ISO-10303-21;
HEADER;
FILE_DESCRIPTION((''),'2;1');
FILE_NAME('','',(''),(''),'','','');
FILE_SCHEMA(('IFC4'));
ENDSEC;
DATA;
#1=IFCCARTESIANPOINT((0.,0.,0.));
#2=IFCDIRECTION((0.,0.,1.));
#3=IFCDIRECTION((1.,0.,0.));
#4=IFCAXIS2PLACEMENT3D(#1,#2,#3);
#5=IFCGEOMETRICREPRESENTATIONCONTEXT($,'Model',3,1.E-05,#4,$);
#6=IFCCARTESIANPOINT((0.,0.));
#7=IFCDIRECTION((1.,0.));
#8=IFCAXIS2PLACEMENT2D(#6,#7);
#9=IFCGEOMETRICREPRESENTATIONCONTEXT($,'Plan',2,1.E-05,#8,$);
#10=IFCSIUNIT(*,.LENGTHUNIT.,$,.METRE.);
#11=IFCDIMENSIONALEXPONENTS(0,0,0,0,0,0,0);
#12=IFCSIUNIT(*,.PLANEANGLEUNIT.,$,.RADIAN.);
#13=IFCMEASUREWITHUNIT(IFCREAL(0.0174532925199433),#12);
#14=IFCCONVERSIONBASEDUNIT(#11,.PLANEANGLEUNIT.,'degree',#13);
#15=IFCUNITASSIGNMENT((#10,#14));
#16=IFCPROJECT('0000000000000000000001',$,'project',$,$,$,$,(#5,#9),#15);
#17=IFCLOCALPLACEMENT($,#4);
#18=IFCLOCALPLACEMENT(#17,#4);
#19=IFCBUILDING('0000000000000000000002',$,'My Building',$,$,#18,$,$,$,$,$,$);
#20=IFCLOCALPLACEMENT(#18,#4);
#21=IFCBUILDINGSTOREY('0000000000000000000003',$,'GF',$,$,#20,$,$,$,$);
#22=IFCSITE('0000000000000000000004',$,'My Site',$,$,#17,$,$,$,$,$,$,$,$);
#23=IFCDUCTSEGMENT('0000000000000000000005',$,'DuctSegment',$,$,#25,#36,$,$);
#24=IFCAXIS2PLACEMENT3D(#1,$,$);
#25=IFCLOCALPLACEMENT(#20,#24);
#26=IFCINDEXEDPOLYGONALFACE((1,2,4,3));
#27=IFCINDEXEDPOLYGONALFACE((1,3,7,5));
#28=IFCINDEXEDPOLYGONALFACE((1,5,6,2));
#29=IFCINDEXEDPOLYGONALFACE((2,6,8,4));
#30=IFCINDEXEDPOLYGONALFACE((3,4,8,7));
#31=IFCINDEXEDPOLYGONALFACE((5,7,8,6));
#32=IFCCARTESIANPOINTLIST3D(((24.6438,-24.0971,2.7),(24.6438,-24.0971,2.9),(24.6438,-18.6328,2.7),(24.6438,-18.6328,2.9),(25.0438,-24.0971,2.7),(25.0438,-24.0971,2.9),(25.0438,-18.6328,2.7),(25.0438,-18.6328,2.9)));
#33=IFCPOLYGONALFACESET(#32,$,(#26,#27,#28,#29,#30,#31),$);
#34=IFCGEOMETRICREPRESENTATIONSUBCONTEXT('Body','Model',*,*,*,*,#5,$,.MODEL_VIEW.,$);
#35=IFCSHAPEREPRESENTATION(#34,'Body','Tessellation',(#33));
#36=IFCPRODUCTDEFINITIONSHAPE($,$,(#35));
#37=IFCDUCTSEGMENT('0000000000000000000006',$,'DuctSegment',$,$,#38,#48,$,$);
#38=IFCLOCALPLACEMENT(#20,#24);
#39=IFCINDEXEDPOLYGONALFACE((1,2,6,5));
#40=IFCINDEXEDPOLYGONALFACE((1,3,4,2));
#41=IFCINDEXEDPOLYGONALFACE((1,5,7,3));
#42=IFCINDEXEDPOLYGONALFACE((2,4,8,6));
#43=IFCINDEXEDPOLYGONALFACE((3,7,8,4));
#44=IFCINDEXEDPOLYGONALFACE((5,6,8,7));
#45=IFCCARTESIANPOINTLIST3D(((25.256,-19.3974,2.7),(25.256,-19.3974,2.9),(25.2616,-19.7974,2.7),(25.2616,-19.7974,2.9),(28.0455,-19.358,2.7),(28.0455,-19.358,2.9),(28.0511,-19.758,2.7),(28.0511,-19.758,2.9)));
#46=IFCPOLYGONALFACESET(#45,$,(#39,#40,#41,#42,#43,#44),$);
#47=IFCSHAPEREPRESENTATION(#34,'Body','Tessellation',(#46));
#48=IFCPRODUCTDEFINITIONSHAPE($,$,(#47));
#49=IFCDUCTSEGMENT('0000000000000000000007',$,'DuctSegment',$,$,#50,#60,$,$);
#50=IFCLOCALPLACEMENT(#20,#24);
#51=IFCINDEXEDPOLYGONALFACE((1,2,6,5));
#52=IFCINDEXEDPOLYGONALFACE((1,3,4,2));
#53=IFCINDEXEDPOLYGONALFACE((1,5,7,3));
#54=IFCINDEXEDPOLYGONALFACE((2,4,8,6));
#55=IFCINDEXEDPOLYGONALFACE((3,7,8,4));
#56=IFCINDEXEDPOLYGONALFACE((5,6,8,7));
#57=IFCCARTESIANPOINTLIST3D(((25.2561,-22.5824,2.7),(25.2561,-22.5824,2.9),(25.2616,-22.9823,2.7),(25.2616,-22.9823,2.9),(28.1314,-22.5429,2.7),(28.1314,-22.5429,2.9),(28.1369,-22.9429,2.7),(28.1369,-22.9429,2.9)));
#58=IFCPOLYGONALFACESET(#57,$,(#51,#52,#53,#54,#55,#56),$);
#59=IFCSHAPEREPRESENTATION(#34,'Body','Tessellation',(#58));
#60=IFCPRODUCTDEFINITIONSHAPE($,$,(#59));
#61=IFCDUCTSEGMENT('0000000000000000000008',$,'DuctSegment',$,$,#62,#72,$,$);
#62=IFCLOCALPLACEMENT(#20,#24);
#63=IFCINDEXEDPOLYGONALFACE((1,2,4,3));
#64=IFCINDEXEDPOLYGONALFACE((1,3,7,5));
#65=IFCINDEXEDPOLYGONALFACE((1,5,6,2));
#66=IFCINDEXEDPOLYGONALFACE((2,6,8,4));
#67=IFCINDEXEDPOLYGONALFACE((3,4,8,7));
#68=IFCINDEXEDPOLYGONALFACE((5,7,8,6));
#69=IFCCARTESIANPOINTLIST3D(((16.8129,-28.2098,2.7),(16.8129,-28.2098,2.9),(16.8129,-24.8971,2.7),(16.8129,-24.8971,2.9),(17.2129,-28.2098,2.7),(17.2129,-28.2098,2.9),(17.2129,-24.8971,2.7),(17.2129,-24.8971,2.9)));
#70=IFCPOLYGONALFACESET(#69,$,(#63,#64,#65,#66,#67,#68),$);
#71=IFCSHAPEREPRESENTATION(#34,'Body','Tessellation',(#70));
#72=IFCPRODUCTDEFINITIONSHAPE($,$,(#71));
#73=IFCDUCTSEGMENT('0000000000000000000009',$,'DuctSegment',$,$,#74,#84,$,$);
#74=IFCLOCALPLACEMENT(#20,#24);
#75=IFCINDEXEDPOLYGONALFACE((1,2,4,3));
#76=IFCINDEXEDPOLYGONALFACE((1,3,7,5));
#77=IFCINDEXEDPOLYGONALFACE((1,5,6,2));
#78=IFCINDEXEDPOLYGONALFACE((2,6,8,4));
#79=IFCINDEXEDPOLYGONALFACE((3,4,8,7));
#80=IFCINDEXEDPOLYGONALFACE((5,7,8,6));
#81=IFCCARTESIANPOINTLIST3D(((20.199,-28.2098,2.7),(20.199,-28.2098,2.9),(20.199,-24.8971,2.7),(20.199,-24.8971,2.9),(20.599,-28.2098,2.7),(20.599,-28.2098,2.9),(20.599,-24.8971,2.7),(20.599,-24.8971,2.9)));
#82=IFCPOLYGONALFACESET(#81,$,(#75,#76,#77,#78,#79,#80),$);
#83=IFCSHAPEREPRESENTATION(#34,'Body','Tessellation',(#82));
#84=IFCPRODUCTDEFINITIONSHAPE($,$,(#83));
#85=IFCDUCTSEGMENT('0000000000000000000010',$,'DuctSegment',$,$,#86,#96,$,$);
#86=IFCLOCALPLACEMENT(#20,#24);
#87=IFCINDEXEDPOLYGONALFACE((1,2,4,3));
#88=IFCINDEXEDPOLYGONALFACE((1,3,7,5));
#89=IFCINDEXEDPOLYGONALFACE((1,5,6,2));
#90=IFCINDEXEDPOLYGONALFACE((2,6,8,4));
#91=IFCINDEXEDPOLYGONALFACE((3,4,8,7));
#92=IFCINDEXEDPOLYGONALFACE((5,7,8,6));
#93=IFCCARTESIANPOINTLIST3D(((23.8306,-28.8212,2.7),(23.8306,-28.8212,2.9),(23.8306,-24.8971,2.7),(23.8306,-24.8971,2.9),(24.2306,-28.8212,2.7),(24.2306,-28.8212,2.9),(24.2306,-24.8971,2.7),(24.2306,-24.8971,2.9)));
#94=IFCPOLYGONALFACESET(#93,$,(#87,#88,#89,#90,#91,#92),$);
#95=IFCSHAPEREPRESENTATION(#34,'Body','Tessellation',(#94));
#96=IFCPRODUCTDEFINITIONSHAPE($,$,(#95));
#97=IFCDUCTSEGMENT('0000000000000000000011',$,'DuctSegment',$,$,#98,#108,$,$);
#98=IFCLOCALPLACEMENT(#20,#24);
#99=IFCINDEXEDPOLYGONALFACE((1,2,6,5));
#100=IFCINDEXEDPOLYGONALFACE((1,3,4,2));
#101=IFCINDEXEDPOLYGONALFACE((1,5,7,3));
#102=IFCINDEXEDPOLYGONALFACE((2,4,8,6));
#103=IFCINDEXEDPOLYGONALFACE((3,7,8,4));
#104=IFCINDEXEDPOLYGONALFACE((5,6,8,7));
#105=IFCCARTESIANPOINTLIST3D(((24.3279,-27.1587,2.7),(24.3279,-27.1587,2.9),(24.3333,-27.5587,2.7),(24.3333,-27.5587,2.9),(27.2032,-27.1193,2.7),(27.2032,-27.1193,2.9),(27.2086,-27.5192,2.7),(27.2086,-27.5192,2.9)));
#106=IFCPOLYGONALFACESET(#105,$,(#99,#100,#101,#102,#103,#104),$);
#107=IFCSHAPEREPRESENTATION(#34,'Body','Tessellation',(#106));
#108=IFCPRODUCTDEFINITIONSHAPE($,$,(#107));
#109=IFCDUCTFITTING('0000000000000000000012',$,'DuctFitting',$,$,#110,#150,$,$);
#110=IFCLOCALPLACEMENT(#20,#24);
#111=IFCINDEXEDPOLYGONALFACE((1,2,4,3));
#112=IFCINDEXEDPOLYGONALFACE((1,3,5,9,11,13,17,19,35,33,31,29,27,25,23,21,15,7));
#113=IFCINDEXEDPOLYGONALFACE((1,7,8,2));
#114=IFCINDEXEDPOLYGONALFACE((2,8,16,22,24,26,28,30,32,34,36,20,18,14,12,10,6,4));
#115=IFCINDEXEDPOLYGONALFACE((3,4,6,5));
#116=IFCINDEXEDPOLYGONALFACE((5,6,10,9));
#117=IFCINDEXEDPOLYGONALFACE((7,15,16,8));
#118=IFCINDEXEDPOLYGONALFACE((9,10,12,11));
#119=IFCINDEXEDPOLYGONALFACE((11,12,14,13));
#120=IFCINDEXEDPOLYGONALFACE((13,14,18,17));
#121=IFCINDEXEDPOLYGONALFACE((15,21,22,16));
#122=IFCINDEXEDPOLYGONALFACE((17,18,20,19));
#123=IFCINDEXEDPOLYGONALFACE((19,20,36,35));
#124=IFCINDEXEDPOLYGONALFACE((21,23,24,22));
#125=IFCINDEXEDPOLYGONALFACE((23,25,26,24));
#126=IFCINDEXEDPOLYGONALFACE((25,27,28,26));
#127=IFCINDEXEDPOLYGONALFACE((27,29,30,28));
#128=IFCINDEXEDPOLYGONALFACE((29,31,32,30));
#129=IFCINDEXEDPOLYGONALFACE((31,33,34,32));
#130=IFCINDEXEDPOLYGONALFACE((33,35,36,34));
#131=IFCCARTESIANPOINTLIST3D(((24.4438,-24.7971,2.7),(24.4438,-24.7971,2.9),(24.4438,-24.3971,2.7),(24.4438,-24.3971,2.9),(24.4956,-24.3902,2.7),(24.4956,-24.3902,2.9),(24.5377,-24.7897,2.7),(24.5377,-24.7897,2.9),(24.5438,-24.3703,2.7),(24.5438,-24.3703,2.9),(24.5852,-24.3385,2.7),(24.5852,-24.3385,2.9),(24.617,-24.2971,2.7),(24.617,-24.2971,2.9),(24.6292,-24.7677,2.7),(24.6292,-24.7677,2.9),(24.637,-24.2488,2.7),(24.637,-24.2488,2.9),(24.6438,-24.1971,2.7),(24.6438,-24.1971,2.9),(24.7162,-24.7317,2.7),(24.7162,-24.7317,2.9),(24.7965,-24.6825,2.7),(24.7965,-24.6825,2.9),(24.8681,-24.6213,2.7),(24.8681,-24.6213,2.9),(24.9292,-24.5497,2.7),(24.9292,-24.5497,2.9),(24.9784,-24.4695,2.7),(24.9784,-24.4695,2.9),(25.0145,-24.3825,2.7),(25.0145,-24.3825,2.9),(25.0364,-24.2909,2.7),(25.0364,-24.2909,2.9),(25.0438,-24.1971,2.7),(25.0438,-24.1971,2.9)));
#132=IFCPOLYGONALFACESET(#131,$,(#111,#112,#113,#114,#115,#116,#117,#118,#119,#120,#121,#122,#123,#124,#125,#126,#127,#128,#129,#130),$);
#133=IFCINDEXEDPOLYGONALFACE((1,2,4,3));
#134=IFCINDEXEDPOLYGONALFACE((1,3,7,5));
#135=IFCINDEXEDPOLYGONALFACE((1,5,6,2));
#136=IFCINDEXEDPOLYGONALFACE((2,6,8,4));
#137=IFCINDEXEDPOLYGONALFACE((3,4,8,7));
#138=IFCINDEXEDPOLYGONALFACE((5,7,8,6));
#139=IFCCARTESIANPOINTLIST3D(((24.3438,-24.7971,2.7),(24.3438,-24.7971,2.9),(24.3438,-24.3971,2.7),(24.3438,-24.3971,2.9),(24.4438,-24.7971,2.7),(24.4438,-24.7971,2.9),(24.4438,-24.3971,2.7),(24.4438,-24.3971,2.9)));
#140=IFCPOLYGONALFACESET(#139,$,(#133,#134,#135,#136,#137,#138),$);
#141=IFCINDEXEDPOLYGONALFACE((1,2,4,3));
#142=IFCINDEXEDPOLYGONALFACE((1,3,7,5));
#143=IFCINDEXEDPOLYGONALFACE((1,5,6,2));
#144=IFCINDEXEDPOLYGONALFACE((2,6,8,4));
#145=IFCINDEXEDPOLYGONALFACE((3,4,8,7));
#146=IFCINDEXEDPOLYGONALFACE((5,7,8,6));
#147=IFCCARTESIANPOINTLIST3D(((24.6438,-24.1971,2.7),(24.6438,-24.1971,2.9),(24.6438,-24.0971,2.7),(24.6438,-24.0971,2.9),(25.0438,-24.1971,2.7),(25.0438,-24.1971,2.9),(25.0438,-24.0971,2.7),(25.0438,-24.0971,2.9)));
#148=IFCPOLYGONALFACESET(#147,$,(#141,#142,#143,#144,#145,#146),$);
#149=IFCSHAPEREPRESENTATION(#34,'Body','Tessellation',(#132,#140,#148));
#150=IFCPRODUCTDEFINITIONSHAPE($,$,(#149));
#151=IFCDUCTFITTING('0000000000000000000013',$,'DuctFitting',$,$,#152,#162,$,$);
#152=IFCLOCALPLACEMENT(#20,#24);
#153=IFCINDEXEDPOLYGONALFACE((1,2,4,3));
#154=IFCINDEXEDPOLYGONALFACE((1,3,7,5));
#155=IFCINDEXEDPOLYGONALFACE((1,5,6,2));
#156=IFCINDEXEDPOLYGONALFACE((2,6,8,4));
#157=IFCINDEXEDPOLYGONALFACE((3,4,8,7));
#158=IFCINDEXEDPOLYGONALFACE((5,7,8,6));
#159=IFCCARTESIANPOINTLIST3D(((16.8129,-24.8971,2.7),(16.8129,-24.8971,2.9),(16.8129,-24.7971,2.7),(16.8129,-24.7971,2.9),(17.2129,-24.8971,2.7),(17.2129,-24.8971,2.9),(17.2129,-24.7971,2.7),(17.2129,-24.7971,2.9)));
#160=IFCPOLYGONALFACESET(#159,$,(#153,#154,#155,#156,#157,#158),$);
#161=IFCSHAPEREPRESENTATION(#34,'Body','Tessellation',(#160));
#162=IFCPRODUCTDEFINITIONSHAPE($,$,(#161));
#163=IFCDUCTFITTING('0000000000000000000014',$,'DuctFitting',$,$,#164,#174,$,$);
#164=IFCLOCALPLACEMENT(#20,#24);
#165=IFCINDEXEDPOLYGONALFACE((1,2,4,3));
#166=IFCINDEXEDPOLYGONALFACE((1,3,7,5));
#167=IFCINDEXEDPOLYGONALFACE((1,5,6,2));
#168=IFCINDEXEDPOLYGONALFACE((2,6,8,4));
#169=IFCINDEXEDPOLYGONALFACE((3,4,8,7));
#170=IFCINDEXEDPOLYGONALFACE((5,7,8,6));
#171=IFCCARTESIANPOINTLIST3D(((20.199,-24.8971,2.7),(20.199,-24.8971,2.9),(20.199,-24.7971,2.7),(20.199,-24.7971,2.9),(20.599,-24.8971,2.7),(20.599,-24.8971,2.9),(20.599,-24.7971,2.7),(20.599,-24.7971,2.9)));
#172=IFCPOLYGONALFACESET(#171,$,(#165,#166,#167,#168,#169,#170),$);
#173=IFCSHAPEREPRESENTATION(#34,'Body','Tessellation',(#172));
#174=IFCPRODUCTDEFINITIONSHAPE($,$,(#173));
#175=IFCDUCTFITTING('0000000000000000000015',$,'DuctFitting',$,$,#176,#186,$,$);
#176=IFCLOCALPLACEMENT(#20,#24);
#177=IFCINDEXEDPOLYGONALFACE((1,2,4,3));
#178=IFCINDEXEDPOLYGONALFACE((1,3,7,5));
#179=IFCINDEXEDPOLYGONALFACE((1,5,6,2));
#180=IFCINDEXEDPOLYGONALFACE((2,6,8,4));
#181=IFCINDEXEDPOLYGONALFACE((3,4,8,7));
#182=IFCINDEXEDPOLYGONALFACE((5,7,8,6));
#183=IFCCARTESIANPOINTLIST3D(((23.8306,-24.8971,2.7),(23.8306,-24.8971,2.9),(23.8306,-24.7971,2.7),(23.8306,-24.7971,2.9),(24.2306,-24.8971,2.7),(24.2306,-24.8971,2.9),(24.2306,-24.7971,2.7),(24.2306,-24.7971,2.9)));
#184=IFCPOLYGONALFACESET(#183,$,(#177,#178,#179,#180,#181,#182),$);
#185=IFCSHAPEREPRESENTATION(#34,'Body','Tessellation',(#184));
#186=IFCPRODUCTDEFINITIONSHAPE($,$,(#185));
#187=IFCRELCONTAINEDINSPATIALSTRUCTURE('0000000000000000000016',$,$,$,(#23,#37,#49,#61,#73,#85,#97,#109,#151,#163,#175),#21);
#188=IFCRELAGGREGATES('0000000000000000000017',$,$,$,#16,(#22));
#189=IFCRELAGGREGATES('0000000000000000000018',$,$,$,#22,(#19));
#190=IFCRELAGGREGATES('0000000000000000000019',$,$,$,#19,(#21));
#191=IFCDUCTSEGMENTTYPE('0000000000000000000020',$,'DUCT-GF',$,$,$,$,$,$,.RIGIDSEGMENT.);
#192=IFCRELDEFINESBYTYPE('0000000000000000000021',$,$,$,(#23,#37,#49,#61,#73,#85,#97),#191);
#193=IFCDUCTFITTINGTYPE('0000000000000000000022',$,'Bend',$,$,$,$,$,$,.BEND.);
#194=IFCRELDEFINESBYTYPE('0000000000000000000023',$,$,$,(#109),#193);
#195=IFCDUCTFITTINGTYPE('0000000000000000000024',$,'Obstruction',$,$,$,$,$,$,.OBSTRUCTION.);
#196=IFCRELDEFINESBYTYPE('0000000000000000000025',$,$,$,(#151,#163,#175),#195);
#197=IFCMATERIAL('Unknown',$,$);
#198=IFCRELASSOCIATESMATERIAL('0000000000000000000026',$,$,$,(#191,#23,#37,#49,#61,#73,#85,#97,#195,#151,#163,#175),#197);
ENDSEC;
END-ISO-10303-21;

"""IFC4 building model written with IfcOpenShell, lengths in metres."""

from ifc_helpers import new_model, entity, si_unit, converted_unit, frame, origin_with_axes, origin_2d_with_axis, place, context, subcontext, project, spatial, line, arc, indexed_curve, rectangle, outline, extrude, source, transform, mapped, material, material_profile, profile_set, profile_usage, type_object, type_shapes, element, save


model = new_model("IFC4")

# Units and contexts
model_context = context("Model", 3, precision=1e-05, world=origin_with_axes())
plan_context = context("Plan", 2, precision=1e-05, world=origin_2d_with_axis())
body_context_1 = subcontext(model_context, "Body", "Model", "MODEL_VIEW")
ifc_project = project(units=[si_unit("LENGTHUNIT", "METRE"), converted_unit("PLANEANGLEUNIT", "degree", entity("IfcReal", 0.0174532925199433), si_unit("PLANEANGLEUNIT", "RADIAN"), dimensions=[0, 0, 0, 0, 0, 0, 0])], contexts=[model_context, plan_context])

# Site, building, storey
site_placement = place(None, origin_with_axes())
site = spatial("IfcSite", under=ifc_project, at=site_placement, Name="My Site")
building_placement = place(site_placement, origin_with_axes())
building = spatial("IfcBuilding", under=site, at=building_placement, Name="My Building")
storey_placement = place(building_placement, origin_with_axes())
storey = spatial("IfcBuildingStorey", under=building, at=storey_placement, Name="GF")

# Shared definitions
ifc_material = material(Name="Unknown")

# Duct segments
ifc_material_profile_1 = material_profile(ifc_material, rectangle(XDim=0.4, YDim=0.2))
ifc_profile_set_1 = profile_set([ifc_material_profile_1])
ifc_profile_usage_1 = profile_usage(ifc_profile_set_1, cardinal=5)
duct_segment_type = type_object("IfcDuctSegmentType", Name="DUCT-GF", PredefinedType="RIGIDSEGMENT", material=ifc_profile_set_1)
duct_segment_1_placement = place(storey_placement, frame((24.8438, -18.6328, 2.8), z_axis=(0.0, -1.0, 0.0), x_axis=(1.0, 0.0, 0.0)))
element("IfcDuctSegment", 1, at=duct_segment_1_placement, inside=storey, type_object=duct_segment_type, material=ifc_profile_usage_1, Name="DuctSegment", context=body_context_1, shape_type="SweptSolid", body=[
    extrude(rectangle(XDim=0.4, YDim=0.2), origin_with_axes(), (0.0, 0.0, 1.0), 5.4642),
])
ifc_profile_usage_2 = profile_usage(ifc_profile_set_1, cardinal=5)
duct_segment_2_placement = place(storey_placement, frame((25.2588, -19.5974, 2.8), z_axis=(0.9999, 0.01412, 0.0), x_axis=(-0.01412, 0.9999, 0.0)))
element("IfcDuctSegment", 2, at=duct_segment_2_placement, inside=storey, type_object=duct_segment_type, material=ifc_profile_usage_2, Name="DuctSegment", context=body_context_1, shape_type="SweptSolid", body=[
    extrude(rectangle(XDim=0.4, YDim=0.2), origin_with_axes(), (0.0, 0.0, 1.0), 2.7897),
])
ifc_profile_usage_3 = profile_usage(ifc_profile_set_1, cardinal=5)
duct_segment_3_placement = place(storey_placement, frame((25.2588, -22.7824, 2.8), z_axis=(0.999906, 0.013713, 0.0), x_axis=(-0.013713, 0.999906, 0.0)))
element("IfcDuctSegment", 3, at=duct_segment_3_placement, inside=storey, type_object=duct_segment_type, material=ifc_profile_usage_3, Name="DuctSegment", context=body_context_1, shape_type="SweptSolid", body=[
    extrude(rectangle(XDim=0.4, YDim=0.2), origin_with_axes(), (0.0, 0.0, 1.0), 2.8756),
])
ifc_profile_usage_4 = profile_usage(ifc_profile_set_1, cardinal=5)
duct_segment_4_placement = place(storey_placement, frame((17.0129, -24.8971, 2.8), z_axis=(0.0, -1.0, 0.0), x_axis=(1.0, 0.0, 0.0)))
element("IfcDuctSegment", 4, at=duct_segment_4_placement, inside=storey, type_object=duct_segment_type, material=ifc_profile_usage_4, Name="DuctSegment", context=body_context_1, shape_type="SweptSolid", body=[
    extrude(rectangle(XDim=0.4, YDim=0.2), origin_with_axes(), (0.0, 0.0, 1.0), 3.3127),
])
ifc_profile_usage_5 = profile_usage(ifc_profile_set_1, cardinal=5)
duct_segment_5_placement = place(storey_placement, frame((20.399, -24.8971, 2.8), z_axis=(0.0, -1.0, 0.0), x_axis=(1.0, 0.0, 0.0)))
element("IfcDuctSegment", 5, at=duct_segment_5_placement, inside=storey, type_object=duct_segment_type, material=ifc_profile_usage_5, Name="DuctSegment", context=body_context_1, shape_type="SweptSolid", body=[
    extrude(rectangle(XDim=0.4, YDim=0.2), origin_with_axes(), (0.0, 0.0, 1.0), 3.3127),
])
ifc_profile_usage_6 = profile_usage(ifc_profile_set_1, cardinal=5)
duct_segment_6_placement = place(storey_placement, frame((24.0306, -28.8212, 2.8), z_axis=(0.0, 1.0, 0.0), x_axis=(-1.0, 0.0, 0.0)))
element("IfcDuctSegment", 6, at=duct_segment_6_placement, inside=storey, type_object=duct_segment_type, material=ifc_profile_usage_6, Name="DuctSegment", context=body_context_1, shape_type="SweptSolid", body=[
    extrude(rectangle(XDim=0.4, YDim=0.2), origin_with_axes(), (0.0, 0.0, 1.0), 3.9241),
])
ifc_profile_usage_7 = profile_usage(ifc_profile_set_1, cardinal=5)
duct_segment_7_placement = place(storey_placement, frame((24.3306, -27.3587, 2.8), z_axis=(0.999906, 0.013713, 0.0), x_axis=(-0.013713, 0.999906, 0.0)))
element("IfcDuctSegment", 7, at=duct_segment_7_placement, inside=storey, type_object=duct_segment_type, material=ifc_profile_usage_7, Name="DuctSegment", context=body_context_1, shape_type="SweptSolid", body=[
    extrude(rectangle(XDim=0.4, YDim=0.2), origin_with_axes(), (0.0, 0.0, 1.0), 2.8756),
])

# Duct fittings
duct_fitting_type_1 = type_object("IfcDuctFittingType", Name="Bend", PredefinedType="BEND")
shared_shape_1 = source(origin_with_axes(), body_context_1, "Body", "SweptSolid", [
    extrude(outline(indexed_curve([(0.2, 0.0), (0.2586, -0.1414), (0.4, -0.2), (0.4, -0.6), (-0.0243, -0.4243), (-0.2, 0.0)], segments=[arc(1, 2, 3), line(3, 4), arc(4, 5, 6), line(6, 1)])), frame((0.0, -0.1, -0.1), z_axis=(0.0, -1.0, 0.0), x_axis=(1.0, 0.0, 0.0)), (0.0, 0.0, -1.0), 0.2),
    extrude(rectangle(XDim=0.4, YDim=0.2), origin_with_axes(), (0.0, 0.0, -1.0), 0.1),
    extrude(rectangle(XDim=0.4, YDim=0.2), frame((0.4, 0.0, -0.5), z_axis=(1.0, 0.0, 0.0), x_axis=(0.0, 0.0, 1.0)), (0.0, 0.0, 1.0), 0.1),
])
type_shapes(duct_fitting_type_1, [shared_shape_1])
duct_fitting_1_placement = place(storey_placement, frame((24.3438, -24.5971, 2.8), z_axis=(-1.0, 0.0, 0.0), x_axis=(0.0, 1.0, 0.0)))
element("IfcDuctFitting", 8, at=duct_fitting_1_placement, inside=storey, type_object=duct_fitting_type_1, Name="DuctFitting", context=body_context_1, shape_type="MappedRepresentation", body=[
    mapped(shared_shape_1, transform((0.0, 0.0, 0.0), x_axis=(1.0, 0.0, 0.0), y_axis=(0.0, 1.0, 0.0), z_axis=(0.0, 0.0, 1.0), scale=1.0)),
])
ifc_material_profile_2 = material_profile(ifc_material, rectangle(XDim=0.4, YDim=0.2))
ifc_profile_set_2 = profile_set([ifc_material_profile_2])
ifc_profile_usage_8 = profile_usage(ifc_profile_set_2, cardinal=5)
duct_fitting_type_2 = type_object("IfcDuctFittingType", Name="Obstruction", PredefinedType="OBSTRUCTION", material=ifc_profile_set_2)
duct_fitting_2_placement = place(storey_placement, frame((17.0129, -24.7971, 2.8), z_axis=(0.0, -1.0, 0.0), x_axis=(1.0, 0.0, 0.0)))
element("IfcDuctFitting", 9, at=duct_fitting_2_placement, inside=storey, type_object=duct_fitting_type_2, material=ifc_profile_usage_8, Name="DuctFitting", context=body_context_1, shape_type="SweptSolid", body=[
    extrude(rectangle(XDim=0.4, YDim=0.2), origin_with_axes(), (0.0, 0.0, 1.0), 0.1),
])
ifc_profile_usage_9 = profile_usage(ifc_profile_set_2, cardinal=5)
duct_fitting_3_placement = place(storey_placement, frame((20.399, -24.7971, 2.8), z_axis=(0.0, -1.0, 0.0), x_axis=(1.0, 0.0, 0.0)))
element("IfcDuctFitting", 10, at=duct_fitting_3_placement, inside=storey, type_object=duct_fitting_type_2, material=ifc_profile_usage_9, Name="DuctFitting", context=body_context_1, shape_type="SweptSolid", body=[
    extrude(rectangle(XDim=0.4, YDim=0.2), origin_with_axes(), (0.0, 0.0, 1.0), 0.1),
])
ifc_profile_usage_10 = profile_usage(ifc_profile_set_2, cardinal=5)
duct_fitting_4_placement = place(storey_placement, frame((24.0306, -24.8971, 2.8), z_axis=(0.0, 1.0, 0.0), x_axis=(-1.0, 0.0, 0.0)))
element("IfcDuctFitting", 11, at=duct_fitting_4_placement, inside=storey, type_object=duct_fitting_type_2, material=ifc_profile_usage_10, Name="DuctFitting", context=body_context_1, shape_type="SweptSolid", body=[
    extrude(rectangle(XDim=0.4, YDim=0.2), origin_with_axes(), (0.0, 0.0, 1.0), 0.1),
])

save(model, "model.ifc")
